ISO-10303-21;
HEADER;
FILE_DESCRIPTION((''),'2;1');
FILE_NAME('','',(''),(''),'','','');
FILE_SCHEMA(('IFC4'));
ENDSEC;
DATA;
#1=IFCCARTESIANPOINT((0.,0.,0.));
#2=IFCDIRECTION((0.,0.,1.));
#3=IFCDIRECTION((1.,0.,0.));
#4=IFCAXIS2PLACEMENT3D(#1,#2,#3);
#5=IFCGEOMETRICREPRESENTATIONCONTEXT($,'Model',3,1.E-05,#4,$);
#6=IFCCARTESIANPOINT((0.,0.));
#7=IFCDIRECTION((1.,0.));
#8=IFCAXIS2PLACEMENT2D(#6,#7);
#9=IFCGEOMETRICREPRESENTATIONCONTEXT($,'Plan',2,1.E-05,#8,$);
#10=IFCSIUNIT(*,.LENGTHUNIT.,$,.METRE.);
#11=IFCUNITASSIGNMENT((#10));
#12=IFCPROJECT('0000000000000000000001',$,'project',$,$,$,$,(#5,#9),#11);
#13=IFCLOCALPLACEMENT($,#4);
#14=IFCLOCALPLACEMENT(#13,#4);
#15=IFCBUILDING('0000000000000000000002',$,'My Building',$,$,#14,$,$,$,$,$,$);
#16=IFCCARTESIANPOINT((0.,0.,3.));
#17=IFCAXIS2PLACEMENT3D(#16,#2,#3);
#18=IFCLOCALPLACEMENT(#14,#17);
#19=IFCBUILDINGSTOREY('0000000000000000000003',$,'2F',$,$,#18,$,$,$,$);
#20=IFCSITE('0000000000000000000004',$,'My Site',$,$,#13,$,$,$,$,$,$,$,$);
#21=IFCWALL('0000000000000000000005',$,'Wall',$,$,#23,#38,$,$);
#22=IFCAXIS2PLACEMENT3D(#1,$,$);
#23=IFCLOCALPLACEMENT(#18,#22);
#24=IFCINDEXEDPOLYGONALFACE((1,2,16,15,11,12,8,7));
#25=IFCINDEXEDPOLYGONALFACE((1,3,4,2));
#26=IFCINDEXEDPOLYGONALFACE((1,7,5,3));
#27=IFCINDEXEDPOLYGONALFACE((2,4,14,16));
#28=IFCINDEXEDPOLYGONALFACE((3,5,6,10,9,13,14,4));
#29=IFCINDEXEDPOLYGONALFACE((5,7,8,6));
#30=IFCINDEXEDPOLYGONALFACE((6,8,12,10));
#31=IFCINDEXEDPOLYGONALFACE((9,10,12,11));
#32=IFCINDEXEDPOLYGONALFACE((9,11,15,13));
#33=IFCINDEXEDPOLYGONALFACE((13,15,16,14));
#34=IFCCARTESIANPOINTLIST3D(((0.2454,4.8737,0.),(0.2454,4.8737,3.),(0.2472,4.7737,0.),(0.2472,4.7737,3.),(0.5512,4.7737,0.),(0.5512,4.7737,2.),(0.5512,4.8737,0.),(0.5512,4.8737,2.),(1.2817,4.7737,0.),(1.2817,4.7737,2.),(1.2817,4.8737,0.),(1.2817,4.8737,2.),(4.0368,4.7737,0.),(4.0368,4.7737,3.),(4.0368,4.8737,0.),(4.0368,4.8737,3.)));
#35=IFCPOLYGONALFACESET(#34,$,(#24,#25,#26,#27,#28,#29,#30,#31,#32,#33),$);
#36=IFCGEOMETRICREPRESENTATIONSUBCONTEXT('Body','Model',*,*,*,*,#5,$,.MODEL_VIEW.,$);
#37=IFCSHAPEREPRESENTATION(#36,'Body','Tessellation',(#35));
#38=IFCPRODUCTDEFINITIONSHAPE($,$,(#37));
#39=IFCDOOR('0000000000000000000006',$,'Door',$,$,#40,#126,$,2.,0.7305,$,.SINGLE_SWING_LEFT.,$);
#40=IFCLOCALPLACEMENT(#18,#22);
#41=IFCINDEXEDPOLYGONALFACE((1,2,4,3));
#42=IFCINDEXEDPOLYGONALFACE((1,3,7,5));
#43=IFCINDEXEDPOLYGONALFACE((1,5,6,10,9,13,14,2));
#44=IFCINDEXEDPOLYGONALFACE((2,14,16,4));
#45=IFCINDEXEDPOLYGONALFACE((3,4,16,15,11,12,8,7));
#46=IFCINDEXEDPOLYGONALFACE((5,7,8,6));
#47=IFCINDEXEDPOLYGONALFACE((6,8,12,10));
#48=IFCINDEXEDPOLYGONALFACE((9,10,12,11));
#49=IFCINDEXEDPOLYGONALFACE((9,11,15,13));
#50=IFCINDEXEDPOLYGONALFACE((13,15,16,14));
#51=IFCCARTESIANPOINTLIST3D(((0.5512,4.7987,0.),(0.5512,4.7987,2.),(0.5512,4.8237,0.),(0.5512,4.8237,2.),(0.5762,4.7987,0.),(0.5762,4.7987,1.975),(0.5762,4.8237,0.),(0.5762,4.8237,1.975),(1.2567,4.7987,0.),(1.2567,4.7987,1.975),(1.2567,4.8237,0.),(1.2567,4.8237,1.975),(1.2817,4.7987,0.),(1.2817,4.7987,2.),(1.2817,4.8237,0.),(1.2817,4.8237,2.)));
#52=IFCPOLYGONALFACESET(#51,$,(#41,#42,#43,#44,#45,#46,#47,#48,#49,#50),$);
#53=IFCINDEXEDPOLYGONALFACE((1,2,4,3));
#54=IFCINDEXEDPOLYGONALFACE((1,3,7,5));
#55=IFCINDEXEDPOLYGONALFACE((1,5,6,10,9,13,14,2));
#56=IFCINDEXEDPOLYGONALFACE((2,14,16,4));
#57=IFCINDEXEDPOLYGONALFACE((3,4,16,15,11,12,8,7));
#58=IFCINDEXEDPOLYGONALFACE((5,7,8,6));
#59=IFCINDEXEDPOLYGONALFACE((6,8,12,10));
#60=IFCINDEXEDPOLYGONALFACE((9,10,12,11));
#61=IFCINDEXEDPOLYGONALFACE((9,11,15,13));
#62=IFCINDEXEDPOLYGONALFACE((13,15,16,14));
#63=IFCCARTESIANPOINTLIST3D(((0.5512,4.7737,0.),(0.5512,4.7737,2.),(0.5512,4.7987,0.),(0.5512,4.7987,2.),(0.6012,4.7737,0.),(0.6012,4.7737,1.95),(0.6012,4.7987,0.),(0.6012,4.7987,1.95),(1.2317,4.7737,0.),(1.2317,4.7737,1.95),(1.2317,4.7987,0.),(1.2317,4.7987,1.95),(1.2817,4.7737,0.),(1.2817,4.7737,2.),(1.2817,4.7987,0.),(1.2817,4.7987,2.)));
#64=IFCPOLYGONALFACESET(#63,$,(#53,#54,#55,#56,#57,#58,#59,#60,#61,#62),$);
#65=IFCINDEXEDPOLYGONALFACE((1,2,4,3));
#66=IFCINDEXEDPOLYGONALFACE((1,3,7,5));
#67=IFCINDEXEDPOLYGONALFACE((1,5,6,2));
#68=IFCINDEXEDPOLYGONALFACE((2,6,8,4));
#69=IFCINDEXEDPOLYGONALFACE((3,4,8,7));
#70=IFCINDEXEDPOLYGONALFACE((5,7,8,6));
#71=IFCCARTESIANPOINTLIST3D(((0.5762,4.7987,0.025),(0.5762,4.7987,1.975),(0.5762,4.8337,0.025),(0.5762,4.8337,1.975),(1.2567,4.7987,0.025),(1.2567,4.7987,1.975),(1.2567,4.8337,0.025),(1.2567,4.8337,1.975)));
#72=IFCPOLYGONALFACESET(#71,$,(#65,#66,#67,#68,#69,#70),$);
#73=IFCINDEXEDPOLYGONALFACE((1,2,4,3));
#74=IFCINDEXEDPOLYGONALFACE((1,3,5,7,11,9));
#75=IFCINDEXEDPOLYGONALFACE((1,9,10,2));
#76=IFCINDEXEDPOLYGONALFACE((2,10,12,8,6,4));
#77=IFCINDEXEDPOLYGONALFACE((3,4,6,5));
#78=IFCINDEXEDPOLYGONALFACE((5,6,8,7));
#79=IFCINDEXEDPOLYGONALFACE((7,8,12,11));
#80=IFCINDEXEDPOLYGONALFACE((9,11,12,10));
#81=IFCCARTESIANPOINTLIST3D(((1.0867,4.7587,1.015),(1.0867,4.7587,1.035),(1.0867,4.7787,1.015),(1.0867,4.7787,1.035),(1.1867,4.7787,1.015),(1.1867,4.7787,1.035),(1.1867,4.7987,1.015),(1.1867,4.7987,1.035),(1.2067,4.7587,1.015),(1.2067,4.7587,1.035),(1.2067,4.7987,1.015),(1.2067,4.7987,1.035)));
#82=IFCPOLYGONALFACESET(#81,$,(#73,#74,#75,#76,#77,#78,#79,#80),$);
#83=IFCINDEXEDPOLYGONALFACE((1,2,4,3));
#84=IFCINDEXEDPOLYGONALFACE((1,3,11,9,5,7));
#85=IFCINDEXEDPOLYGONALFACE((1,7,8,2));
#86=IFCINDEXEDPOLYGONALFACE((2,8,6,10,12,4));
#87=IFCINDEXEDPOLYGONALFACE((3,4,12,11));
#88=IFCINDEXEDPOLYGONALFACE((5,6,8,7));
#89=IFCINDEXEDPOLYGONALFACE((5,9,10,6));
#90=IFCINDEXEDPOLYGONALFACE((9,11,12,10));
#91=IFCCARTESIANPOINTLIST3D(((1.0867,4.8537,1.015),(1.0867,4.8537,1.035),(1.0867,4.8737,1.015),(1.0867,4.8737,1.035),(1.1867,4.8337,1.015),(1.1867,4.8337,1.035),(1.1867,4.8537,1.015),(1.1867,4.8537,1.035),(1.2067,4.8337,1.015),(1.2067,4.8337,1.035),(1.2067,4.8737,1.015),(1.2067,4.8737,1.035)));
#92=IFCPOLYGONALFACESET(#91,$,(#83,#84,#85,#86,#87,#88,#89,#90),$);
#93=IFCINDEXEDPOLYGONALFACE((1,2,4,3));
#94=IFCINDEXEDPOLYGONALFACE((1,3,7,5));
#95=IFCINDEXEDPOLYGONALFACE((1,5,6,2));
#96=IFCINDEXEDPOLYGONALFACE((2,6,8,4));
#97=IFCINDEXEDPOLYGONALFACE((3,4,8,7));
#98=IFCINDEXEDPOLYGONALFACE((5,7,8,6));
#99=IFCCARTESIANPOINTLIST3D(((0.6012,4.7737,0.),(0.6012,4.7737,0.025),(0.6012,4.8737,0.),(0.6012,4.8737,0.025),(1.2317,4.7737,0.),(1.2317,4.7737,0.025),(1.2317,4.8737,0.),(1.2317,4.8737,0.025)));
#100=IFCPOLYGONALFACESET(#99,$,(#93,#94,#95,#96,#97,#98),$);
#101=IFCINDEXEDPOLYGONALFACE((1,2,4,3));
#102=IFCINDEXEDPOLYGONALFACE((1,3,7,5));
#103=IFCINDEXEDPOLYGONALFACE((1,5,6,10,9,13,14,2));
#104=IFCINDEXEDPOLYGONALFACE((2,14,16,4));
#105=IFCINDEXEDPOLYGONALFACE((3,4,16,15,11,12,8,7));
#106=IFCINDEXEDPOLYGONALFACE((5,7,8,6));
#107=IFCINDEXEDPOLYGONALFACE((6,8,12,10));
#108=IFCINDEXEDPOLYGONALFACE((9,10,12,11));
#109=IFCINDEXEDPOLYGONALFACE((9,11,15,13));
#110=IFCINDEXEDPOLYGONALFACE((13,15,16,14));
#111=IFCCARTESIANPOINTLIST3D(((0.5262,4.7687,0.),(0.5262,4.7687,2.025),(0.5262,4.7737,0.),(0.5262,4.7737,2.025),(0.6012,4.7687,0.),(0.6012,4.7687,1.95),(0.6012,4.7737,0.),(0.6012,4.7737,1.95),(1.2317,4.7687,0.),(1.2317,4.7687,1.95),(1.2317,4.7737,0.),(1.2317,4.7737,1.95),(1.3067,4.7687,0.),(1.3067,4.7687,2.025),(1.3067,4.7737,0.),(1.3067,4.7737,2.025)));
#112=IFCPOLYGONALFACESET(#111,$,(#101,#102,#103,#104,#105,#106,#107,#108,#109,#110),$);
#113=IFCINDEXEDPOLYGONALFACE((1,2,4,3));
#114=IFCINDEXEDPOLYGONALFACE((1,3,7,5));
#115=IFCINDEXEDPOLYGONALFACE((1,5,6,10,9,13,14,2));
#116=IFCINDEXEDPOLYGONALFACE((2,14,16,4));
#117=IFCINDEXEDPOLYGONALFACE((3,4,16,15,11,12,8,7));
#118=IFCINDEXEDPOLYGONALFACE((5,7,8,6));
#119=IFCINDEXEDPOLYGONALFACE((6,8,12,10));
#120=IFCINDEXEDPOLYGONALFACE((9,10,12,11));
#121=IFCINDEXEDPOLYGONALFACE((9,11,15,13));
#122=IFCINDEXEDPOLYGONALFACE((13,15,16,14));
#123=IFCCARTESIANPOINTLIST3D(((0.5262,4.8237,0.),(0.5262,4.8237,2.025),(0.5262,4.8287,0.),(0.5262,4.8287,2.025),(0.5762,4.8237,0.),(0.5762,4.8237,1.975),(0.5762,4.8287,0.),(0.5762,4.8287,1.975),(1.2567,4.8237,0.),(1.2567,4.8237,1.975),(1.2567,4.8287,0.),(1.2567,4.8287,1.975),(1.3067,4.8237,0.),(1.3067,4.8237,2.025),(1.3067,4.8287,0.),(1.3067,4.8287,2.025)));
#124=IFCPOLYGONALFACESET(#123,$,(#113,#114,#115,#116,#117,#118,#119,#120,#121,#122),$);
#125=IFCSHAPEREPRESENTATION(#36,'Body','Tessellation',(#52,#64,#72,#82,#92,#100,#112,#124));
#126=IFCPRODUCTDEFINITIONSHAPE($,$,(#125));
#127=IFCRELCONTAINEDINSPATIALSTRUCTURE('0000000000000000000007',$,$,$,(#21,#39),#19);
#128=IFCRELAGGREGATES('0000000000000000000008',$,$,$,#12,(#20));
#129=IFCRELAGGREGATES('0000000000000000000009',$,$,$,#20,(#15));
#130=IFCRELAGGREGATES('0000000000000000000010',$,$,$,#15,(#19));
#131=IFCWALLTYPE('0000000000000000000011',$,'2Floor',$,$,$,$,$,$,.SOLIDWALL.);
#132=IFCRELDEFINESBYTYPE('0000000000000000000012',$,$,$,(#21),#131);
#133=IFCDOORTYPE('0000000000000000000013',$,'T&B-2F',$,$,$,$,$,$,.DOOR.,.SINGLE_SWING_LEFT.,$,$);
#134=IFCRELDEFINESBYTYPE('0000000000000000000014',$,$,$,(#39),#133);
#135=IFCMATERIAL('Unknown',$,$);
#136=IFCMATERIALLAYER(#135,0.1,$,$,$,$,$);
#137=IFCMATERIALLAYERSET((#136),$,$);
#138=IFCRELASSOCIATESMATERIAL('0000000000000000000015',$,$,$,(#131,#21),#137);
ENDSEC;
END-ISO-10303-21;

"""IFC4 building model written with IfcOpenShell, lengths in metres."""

from ifc_helpers import new_model, entity, si_unit, frame, origin_with_axes, origin_2d_with_axis, place, context, subcontext, project, spatial, line, indexed_curve, outline, extrude, shape, source, transform, mapped, material, layer, layer_set, layer_usage, type_object, type_shapes, element, fill, save


model = new_model("IFC4")

# Units and contexts
model_context = context("Model", 3, precision=1e-05, world=origin_with_axes())
plan_context = context("Plan", 2, precision=1e-05, world=origin_2d_with_axis())
body_context_1 = subcontext(model_context, "Body", "Model", "MODEL_VIEW")
body_context_2 = subcontext(plan_context, "Body", "Plan", "PLAN_VIEW")
ifc_project = project(units=[si_unit("LENGTHUNIT", "METRE")], contexts=[model_context, plan_context])

# Site, building, storey
site_placement = place(None, origin_with_axes())
site = spatial("IfcSite", under=ifc_project, at=site_placement, Name="My Site")
building_placement = place(site_placement, origin_with_axes())
building = spatial("IfcBuilding", under=site, at=building_placement, Name="My Building")
storey_placement = place(building_placement, frame((0.0, 0.0, 3.0), z_axis=(0.0, 0.0, 1.0), x_axis=(1.0, 0.0, 0.0)))
storey = spatial("IfcBuildingStorey", under=building, at=storey_placement, Name="2F")

# Shared definitions
ifc_material = material(Name="Unknown")

# Shared definitions
ifc_layer_1 = layer(ifc_material, 0.1)
ifc_layer_set_1 = layer_set([ifc_layer_1])
wall_type = type_object("IfcWallType", Name="2Floor", PredefinedType="SOLIDWALL", material=ifc_layer_set_1)

# Wall, opening, door
ifc_layer_usage_1 = layer_usage(ifc_layer_set_1, "AXIS2", "POSITIVE", 0.0)
wall_1_placement = place(storey_placement, frame((4.1368, 4.8737, 0.0), z_axis=(0.0, 0.0, 1.0), x_axis=(-1.0, 0.0, 0.0)))
wall_1 = element("IfcWall", 1, at=wall_1_placement, inside=storey, type_object=wall_type, material=ifc_layer_usage_1, Name="Wall", context=body_context_1, shape_type="SweptSolid", body=[
    extrude(outline(indexed_curve([(0.1, 0.0), (0.1, 0.1), (3.8896, 0.1), (3.8914, 0.0)], segments=[line(1, 2, 3, 4, 1)])), origin_with_axes(), (0.0, 0.0, 1.0), 3.0),
])
shared_shape_1 = source(origin_with_axes(), body_context_1, "Body", "SweptSolid", [
    extrude(outline(indexed_curve([(0.0, 0.0), (0.7305, 0.0), (0.7305, 2.0), (0.0, 2.0)], segments=[line(1, 2, 3, 4, 1)])), frame((0.0, -0.6, 0.0), z_axis=(0.0, -1.0, 0.0), x_axis=(1.0, 0.0, 0.0)), (0.0, 0.0, -1.0), 1.2),
])
opening_1_placement = place(wall_1_placement, frame((3.5856, 0.1, 0.0), z_axis=(0.0, 0.0, 1.0), x_axis=(-1.0, 0.0, 0.0)))
opening_1 = element("IfcOpeningElement", 2, at=opening_1_placement, cuts=wall_1, PredefinedType="OPENING", context=body_context_1, shape_type="MappedRepresentation", body=[
    mapped(shared_shape_1, transform((0.0, 0.0, 0.0), x_axis=(1.0, 0.0, 0.0), y_axis=(0.0, 1.0, 0.0), z_axis=(0.0, 0.0, 1.0), scale=1.0)),
])
door_type_1 = type_object("IfcDoorType", Name="T&B-2F", OperationType="SINGLE_SWING_LEFT", PredefinedType="DOOR")
shared_shape_2 = source(origin_with_axes(), body_context_1, "Body", "SweptSolid", [
    extrude(outline(indexed_curve([(0.0, 0.0), (0.0, 2.0), (0.7305, 2.0), (0.7305, 0.0), (0.7055, 0.0), (0.7055, 1.975), (0.025, 1.975), (0.025, 0.0)], segments=[line(1, 2, 3, 4, 5, 6, 7, 8, 1)])), frame((0.0, 0.025, 0.0), z_axis=(0.0, -1.0, 0.0), x_axis=(1.0, 0.0, 0.0)), (0.0, 0.0, -1.0), 0.025),
    extrude(outline(indexed_curve([(0.0, 0.0), (0.0, 2.0), (0.7305, 2.0), (0.7305, 0.0), (0.6805, 0.0), (0.6805, 1.95), (0.05, 1.95), (0.05, 0.0)], segments=[line(1, 2, 3, 4, 5, 6, 7, 8, 1)])), frame((0.0, 0.0, 0.0), z_axis=(0.0, -1.0, 0.0), x_axis=(1.0, 0.0, 0.0)), (0.0, 0.0, -1.0), 0.025),
    extrude(outline(indexed_curve([(0.0, 0.0), (0.6805, 0.0), (0.6805, 0.035), (0.0, 0.035)], segments=[line(1, 2, 3, 4, 1)])), frame((0.025, 0.025, 0.025), z_axis=(0.0, 0.0, 1.0), x_axis=(1.0, 0.0, 0.0)), (0.0, 0.0, 1.0), 1.95),
    extrude(outline(indexed_curve([(0.0, 0.0), (0.0, -0.04), (-0.12, -0.04), (-0.12, -0.02), (-0.02, -0.02), (-0.02, 0.0)], segments=[line(1, 2, 3, 4, 5, 6, 1)])), frame((0.6555, 0.025, 1.015), z_axis=(0.0, 0.0, 1.0), x_axis=(1.0, 0.0, 0.0)), (0.0, 0.0, 1.0), 0.02),
    extrude(outline(indexed_curve([(0.0, 0.0), (0.0, 0.04), (-0.12, 0.04), (-0.12, 0.02), (-0.02, 0.02), (-0.02, 0.0)], segments=[line(1, 2, 3, 4, 5, 6, 1)])), frame((0.6555, 0.06, 1.015), z_axis=(0.0, 0.0, 1.0), x_axis=(1.0, 0.0, 0.0)), (0.0, 0.0, 1.0), 0.02),
    extrude(outline(indexed_curve([(0.0, 0.0), (0.6305, 0.0), (0.6305, 0.1), (0.0, 0.1)], segments=[line(1, 2, 3, 4, 1)])), frame((0.05, 0.0, 0.0), z_axis=(0.0, 0.0, 1.0), x_axis=(1.0, 0.0, 0.0)), (0.0, 0.0, 1.0), 0.025),
    extrude(outline(indexed_curve([(0.0, 0.0), (0.0, 2.025), (0.7805, 2.025), (0.7805, 0.0), (0.7055, 0.0), (0.7055, 1.95), (0.075, 1.95), (0.075, 0.0)], segments=[line(1, 2, 3, 4, 5, 6, 7, 8, 1)])), frame((-0.025, -0.005, 0.0), z_axis=(0.0, -1.0, 0.0), x_axis=(1.0, 0.0, 0.0)), (0.0, 0.0, -1.0), 0.005),
    extrude(outline(indexed_curve([(0.0, 0.0), (0.0, 2.025), (0.7805, 2.025), (0.7805, 0.0), (0.7305, 0.0), (0.7305, 1.975), (0.05, 1.975), (0.05, 0.0)], segments=[line(1, 2, 3, 4, 5, 6, 7, 8, 1)])), frame((-0.025, 0.05, 0.0), z_axis=(0.0, -1.0, 0.0), x_axis=(1.0, 0.0, 0.0)), (0.0, 0.0, -1.0), 0.005),
])
shared_shape_3 = source(origin_with_axes(), body_context_2, "Body", "Curve2D", [
    entity("IfcIndexedPolyCurve", entity("IfcCartesianPointList2D", [[0.0, 0.0], [0.0, 0.05], [0.025, 0.05], [0.025, 0.025], [0.05, 0.025], [0.05, 0.0]]), [entity("IfcLineIndex", [1, 2, 3, 4, 5, 6, 1])]),
    entity("IfcIndexedPolyCurve", entity("IfcCartesianPointList2D", [[0.7305, 0.0], [0.7305, 0.05], [0.7055, 0.05], [0.7055, 0.025], [0.6805, 0.025], [0.6805, 0.0]]), [entity("IfcLineIndex", [1, 2, 3, 4, 5, 6, 1])]),
    entity("IfcTrimmedCurve", entity("IfcEllipse", entity("IfcAxis2Placement2D", entity("IfcCartesianPoint", [0.06, 0.05]), entity("IfcDirection", [1.0, 0.0])), 0.6455, 0.6805), [entity("IfcCartesianPoint", [0.7055, 0.05])], [entity("IfcCartesianPoint", [0.06, 0.7305])], True, "CARTESIAN"),
    entity("IfcIndexedPolyCurve", entity("IfcCartesianPointList2D", [[0.025, 0.05], [0.06, 0.05], [0.06, 0.7305], [0.025, 0.7305]]), [entity("IfcLineIndex", [1, 2, 3, 4, 1])]),
])
type_shapes(door_type_1, [shared_shape_2, shared_shape_3])
door_1_placement = place(opening_1_placement, frame((0.0, 0.0, 0.0), z_axis=(0.0, 0.0, 1.0), x_axis=(1.0, 0.0, 0.0)))
door_1 = element("IfcDoor", 3, at=door_1_placement, inside=storey, type_object=door_type_1, Name="Door", OperationType="SINGLE_SWING_LEFT", OverallHeight=2.0, OverallWidth=0.7305, shapes=[
    shape(body_context_1, "Body", "MappedRepresentation", [mapped(shared_shape_2, transform((0.0, 0.0, 0.0), x_axis=(1.0, 0.0, 0.0), y_axis=(0.0, 1.0, 0.0), z_axis=(0.0, 0.0, 1.0), scale=1.0))]),
    shape(body_context_2, "Body", "MappedRepresentation", [mapped(shared_shape_3, transform((0.0, 0.0, 0.0), x_axis=(1.0, 0.0, 0.0), y_axis=(0.0, 1.0, 0.0), z_axis=(0.0, 0.0, 1.0), scale=1.0))]),
])
fill(opening_1, door_1)

save(model, "model.ifc")
